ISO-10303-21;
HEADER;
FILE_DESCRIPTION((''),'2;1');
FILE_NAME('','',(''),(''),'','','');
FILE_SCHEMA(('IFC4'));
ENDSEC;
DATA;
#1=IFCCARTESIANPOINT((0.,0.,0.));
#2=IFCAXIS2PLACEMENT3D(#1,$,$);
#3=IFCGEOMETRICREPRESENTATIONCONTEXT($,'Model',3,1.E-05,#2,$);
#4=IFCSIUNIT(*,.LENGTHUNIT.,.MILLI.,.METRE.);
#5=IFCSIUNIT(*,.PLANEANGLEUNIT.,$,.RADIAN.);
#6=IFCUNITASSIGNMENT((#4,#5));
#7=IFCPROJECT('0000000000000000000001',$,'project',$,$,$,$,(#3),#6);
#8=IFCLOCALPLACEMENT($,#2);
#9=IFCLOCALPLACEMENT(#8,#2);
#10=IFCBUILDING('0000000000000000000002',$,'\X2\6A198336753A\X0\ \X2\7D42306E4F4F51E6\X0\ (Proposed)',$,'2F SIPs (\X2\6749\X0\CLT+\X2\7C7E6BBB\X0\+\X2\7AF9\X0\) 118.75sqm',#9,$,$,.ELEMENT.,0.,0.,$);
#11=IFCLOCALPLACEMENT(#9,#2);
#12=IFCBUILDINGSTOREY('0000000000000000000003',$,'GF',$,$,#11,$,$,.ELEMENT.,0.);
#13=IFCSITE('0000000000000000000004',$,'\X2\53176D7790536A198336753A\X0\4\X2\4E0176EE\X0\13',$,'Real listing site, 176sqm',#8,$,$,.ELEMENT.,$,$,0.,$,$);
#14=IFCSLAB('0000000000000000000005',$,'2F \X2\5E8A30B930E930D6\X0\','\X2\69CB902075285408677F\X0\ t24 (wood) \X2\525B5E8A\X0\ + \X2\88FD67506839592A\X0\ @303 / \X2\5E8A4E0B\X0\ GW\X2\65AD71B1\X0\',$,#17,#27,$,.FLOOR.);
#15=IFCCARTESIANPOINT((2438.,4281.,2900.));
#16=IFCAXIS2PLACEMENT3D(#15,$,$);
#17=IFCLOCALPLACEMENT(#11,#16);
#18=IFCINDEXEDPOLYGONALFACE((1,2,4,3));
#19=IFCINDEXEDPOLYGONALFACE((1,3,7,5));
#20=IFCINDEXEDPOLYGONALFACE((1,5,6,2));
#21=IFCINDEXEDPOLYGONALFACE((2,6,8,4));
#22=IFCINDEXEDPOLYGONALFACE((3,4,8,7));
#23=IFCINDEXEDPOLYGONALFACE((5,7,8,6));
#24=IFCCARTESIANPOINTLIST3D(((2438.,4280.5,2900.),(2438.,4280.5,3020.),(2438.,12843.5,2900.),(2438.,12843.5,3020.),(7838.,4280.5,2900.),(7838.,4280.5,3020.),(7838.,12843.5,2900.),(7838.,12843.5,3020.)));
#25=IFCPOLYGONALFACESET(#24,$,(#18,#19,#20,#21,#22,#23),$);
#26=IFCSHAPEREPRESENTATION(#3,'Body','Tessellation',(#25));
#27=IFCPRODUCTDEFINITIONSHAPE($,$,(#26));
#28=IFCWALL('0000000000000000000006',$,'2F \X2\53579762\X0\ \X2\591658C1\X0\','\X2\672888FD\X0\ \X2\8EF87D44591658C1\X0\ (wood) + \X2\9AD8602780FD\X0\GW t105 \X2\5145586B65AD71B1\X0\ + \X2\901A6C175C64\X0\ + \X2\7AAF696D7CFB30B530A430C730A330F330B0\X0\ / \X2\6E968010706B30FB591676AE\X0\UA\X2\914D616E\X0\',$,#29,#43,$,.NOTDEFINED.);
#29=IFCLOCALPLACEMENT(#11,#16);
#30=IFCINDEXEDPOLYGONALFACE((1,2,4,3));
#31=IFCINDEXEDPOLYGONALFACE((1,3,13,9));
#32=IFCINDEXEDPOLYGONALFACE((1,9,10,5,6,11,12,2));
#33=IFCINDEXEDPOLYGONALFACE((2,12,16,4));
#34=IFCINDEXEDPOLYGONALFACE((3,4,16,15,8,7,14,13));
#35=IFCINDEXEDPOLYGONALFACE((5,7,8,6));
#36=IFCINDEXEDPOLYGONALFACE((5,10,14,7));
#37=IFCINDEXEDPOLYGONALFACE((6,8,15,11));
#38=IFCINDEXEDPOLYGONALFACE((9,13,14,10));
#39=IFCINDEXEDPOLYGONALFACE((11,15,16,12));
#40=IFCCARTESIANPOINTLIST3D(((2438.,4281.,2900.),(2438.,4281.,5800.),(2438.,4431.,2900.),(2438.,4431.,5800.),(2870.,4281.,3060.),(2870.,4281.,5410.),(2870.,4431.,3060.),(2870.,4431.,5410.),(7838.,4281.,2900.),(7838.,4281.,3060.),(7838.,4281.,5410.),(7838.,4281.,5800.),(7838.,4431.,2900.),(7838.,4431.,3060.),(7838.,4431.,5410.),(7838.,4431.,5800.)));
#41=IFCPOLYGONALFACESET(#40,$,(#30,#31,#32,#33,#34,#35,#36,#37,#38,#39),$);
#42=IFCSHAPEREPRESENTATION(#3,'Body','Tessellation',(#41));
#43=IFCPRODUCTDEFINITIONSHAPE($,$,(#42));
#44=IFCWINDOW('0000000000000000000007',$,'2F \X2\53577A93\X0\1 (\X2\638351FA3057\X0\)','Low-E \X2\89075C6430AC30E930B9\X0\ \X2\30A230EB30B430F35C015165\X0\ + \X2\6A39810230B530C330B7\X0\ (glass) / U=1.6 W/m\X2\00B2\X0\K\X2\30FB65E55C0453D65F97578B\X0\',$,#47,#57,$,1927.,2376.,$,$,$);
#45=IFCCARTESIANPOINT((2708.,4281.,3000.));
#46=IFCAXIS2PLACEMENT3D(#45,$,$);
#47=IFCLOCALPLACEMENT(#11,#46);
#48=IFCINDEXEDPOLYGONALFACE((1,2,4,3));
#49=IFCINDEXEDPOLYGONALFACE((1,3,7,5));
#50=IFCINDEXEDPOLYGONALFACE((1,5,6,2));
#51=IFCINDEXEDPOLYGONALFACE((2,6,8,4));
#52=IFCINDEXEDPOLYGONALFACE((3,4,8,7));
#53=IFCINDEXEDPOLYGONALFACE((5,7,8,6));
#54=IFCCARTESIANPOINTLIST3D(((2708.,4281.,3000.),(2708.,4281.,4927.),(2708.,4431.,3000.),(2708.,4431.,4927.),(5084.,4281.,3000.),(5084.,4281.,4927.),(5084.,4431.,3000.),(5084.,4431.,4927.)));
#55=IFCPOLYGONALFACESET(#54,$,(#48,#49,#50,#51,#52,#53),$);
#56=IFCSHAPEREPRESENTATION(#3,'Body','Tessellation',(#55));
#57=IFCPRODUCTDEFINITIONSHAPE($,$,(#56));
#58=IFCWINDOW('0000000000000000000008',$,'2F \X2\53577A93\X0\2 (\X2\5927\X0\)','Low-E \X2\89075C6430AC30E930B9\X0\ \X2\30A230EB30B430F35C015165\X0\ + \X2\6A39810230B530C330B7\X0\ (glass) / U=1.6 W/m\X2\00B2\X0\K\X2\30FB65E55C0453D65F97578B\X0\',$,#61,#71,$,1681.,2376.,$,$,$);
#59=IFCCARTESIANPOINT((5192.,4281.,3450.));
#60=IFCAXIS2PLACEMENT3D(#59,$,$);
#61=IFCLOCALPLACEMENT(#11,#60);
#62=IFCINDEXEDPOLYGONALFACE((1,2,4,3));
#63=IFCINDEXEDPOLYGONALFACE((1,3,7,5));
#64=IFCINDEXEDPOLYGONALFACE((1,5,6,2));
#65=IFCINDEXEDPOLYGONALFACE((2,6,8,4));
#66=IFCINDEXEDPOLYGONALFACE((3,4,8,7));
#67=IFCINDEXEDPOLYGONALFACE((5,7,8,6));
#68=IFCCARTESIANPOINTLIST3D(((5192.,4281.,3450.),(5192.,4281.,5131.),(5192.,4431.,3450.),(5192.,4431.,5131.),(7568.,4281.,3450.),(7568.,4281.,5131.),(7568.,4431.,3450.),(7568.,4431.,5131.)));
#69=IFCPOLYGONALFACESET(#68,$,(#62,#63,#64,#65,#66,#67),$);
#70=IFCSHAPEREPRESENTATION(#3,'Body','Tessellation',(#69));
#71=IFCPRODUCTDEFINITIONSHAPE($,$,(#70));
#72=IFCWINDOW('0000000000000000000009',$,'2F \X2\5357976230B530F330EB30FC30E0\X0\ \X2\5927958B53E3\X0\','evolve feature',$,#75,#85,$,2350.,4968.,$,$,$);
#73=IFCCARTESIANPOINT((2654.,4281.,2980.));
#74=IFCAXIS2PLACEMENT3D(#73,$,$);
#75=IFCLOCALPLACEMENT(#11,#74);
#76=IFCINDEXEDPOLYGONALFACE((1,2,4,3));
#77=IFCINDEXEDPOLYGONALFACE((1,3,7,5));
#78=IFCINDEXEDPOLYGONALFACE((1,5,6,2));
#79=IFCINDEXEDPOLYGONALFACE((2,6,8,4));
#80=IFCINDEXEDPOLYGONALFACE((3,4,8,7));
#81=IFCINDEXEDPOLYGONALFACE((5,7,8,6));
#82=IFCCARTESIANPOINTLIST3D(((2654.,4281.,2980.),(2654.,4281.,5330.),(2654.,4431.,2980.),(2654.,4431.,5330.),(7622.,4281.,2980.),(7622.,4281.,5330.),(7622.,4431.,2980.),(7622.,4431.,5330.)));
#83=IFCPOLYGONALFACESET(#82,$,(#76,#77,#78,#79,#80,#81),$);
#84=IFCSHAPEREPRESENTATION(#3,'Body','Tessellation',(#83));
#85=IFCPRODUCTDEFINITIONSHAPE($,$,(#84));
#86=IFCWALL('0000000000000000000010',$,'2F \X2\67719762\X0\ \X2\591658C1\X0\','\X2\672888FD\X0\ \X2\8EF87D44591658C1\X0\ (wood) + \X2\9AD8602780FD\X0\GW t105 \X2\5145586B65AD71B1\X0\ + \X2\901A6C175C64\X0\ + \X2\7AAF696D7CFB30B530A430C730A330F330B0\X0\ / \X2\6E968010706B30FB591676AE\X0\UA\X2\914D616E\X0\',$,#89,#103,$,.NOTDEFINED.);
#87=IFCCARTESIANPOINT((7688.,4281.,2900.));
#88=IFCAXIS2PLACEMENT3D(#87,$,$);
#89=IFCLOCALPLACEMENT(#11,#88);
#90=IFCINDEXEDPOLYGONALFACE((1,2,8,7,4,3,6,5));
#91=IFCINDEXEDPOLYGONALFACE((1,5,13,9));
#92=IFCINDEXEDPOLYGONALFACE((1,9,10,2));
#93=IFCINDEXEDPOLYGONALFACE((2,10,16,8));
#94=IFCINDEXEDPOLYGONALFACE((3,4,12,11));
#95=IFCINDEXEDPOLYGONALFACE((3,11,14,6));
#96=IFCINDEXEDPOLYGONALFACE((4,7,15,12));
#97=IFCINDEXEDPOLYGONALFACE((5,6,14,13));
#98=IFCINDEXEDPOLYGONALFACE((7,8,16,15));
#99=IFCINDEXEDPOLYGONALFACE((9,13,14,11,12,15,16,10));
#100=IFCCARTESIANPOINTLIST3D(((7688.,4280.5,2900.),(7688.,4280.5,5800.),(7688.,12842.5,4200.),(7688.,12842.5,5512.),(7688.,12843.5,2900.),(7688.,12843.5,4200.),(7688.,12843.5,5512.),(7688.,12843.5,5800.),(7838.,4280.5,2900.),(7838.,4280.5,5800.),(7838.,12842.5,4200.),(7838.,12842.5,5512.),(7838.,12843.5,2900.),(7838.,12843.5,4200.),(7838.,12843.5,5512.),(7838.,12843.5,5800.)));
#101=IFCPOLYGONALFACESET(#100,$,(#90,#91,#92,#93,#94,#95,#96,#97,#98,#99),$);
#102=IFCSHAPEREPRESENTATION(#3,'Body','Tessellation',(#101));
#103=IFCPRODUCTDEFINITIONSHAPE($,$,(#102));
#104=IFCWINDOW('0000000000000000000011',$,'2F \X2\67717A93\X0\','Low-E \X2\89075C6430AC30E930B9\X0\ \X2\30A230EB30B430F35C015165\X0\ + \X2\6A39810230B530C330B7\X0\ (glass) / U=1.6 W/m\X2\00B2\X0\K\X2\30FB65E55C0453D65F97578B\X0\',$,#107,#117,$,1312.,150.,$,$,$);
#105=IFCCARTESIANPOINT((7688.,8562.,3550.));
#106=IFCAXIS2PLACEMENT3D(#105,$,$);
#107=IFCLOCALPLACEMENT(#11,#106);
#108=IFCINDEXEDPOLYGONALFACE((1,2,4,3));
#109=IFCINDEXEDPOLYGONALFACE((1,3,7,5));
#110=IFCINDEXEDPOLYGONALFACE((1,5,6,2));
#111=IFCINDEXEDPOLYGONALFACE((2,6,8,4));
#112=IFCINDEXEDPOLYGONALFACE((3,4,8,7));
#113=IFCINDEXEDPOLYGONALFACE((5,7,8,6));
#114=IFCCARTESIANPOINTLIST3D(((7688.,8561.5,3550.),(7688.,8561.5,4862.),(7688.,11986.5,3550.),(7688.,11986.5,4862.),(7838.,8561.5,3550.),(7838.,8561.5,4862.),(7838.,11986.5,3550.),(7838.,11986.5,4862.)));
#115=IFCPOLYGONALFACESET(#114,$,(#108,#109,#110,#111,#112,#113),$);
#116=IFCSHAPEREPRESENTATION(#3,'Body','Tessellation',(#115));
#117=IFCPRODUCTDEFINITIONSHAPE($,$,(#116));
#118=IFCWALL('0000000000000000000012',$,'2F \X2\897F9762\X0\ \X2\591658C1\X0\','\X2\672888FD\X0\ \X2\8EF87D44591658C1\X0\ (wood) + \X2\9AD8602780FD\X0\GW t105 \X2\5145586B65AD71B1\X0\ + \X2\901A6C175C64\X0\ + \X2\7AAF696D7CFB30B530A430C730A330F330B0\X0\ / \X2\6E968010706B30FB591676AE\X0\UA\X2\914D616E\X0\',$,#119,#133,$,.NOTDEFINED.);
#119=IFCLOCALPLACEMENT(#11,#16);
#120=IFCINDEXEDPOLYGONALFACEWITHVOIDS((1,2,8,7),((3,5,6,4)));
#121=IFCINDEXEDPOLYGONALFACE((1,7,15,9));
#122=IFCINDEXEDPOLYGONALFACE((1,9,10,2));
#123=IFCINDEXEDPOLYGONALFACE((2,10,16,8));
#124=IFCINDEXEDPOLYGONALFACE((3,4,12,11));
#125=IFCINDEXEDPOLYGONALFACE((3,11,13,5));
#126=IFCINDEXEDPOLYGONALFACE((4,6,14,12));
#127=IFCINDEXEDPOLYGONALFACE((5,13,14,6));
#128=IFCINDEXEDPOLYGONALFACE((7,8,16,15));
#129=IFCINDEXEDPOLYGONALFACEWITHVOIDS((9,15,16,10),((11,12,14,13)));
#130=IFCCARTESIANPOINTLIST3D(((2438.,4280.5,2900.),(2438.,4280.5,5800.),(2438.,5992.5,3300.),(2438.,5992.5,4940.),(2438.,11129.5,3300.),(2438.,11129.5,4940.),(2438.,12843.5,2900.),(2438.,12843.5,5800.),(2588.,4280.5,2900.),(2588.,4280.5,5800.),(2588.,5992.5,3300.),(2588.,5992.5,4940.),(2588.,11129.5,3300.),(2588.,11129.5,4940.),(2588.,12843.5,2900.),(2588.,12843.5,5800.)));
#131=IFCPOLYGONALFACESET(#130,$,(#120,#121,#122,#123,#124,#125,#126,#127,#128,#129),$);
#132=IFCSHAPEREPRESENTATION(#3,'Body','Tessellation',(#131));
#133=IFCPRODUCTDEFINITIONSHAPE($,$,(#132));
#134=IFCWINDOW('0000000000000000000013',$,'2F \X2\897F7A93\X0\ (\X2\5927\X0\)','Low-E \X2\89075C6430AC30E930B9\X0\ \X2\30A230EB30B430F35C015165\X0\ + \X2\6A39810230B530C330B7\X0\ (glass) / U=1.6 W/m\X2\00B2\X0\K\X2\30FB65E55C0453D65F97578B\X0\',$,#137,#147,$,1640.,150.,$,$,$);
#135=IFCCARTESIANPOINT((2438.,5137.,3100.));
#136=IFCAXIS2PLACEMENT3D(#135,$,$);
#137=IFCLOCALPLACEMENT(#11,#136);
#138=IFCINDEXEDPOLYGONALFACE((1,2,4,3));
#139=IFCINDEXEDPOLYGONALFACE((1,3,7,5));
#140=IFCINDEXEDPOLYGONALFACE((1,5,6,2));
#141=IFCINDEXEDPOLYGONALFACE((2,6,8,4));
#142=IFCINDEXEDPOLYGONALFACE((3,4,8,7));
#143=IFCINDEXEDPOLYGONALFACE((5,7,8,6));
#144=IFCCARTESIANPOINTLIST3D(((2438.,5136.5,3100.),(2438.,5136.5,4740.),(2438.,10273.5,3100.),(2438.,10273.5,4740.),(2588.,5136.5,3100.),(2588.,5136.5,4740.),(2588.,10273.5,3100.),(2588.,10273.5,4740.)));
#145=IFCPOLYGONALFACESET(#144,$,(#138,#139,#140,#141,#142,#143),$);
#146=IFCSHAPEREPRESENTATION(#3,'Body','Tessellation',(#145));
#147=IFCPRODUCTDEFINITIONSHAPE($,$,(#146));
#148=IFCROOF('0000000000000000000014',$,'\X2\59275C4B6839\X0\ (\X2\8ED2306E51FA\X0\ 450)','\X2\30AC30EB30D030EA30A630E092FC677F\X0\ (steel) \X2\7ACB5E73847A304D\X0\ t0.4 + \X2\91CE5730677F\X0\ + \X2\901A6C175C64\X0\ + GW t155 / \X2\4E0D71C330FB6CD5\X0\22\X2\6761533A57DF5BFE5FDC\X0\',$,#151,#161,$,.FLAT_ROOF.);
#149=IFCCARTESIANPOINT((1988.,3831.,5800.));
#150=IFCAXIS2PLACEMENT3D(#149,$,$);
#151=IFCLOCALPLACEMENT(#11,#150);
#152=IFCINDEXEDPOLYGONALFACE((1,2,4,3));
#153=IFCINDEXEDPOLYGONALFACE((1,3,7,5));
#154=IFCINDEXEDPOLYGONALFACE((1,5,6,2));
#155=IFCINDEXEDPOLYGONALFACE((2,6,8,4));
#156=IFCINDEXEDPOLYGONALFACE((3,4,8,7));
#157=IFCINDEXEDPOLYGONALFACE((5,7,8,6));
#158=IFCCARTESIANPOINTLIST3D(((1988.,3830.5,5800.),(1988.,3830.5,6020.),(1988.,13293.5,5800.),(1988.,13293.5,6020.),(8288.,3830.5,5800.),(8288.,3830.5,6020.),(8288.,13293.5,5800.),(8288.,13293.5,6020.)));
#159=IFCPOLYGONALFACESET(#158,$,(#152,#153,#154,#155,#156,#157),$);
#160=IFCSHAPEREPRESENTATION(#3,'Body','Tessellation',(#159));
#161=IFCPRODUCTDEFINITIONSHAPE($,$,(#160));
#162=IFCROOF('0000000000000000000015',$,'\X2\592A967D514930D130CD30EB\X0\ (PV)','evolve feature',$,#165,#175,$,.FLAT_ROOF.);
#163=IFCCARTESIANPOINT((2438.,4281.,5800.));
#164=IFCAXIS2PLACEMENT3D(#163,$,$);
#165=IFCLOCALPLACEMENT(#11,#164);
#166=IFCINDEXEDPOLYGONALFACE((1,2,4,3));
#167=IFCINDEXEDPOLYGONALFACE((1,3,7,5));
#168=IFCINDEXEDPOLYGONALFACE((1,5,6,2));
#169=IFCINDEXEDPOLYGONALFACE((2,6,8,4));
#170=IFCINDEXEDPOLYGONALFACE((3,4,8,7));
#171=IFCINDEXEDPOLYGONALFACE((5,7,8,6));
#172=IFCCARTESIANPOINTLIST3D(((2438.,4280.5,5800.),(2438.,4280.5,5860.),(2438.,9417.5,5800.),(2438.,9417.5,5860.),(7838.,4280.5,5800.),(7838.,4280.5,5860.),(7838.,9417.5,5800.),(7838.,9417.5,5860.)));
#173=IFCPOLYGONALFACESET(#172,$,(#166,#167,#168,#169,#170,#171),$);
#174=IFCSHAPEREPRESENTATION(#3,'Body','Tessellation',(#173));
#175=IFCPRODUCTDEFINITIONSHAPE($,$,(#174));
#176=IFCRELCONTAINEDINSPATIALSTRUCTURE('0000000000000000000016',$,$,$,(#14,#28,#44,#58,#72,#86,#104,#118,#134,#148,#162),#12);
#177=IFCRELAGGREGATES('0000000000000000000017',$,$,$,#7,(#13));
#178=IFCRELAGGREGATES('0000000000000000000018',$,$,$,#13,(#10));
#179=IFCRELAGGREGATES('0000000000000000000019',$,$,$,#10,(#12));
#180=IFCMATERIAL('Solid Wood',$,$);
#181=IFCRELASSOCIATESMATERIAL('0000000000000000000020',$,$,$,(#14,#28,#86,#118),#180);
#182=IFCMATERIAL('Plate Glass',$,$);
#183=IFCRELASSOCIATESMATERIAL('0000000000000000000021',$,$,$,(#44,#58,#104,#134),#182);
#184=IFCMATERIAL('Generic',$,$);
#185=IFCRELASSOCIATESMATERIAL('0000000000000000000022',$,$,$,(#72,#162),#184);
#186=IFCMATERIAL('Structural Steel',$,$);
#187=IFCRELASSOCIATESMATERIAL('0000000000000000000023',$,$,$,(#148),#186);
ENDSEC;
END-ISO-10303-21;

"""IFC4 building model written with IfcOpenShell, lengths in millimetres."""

from ifc_helpers import new_model, si_unit, frame, frame_2d, origin, place, context, project, spatial, rectangle, extrude, material, element, fill, save


model = new_model("IFC4")

# Units and contexts
model_context = context("Model", 3, precision=1e-05, world=origin())
ifc_project = project(units=[si_unit("LENGTHUNIT", "METRE", prefix="MILLI"), si_unit("PLANEANGLEUNIT", "RADIAN")], contexts=[model_context])

# Site, building, storey
site_placement = place(None, origin())
site = spatial("IfcSite", under=ifc_project, at=site_placement, Name="北海道標茶町4丁目13", ObjectType="Real listing site, 176sqm", CompositionType="ELEMENT", RefElevation=0.0)
building_placement = place(site_placement, origin())
building = spatial("IfcBuilding", under=site, at=building_placement, Name="標茶町 終の住処 (Proposed)", ObjectType="2F SIPs (杉CLT+籾殻+竹) 118.75sqm", CompositionType="ELEMENT", ElevationOfRefHeight=0.0, ElevationOfTerrain=0.0)
storey_placement = place(building_placement, origin())
storey = spatial("IfcBuildingStorey", under=building, at=storey_placement, Name="GF", CompositionType="ELEMENT", Elevation=0.0)

# Slab
ifc_material_1 = material(Name="Solid Wood")
slab_placement = place(storey_placement, frame((2438.0, 4281.0, 2900.0)))
element("IfcSlab", 1, at=slab_placement, inside=storey, material=ifc_material_1, Name="2F 床スラブ", Description="構造用合板 t24 (wood) 剛床 + 製材根太 @303 / 床下 GW断熱", PredefinedType="FLOOR", context=model_context, shape_type="SweptSolid", body=[
    extrude(rectangle(XDim=5400.0, YDim=8563.0, at=frame_2d((2700.0, 4281.0))), frame((2438.0, 4281.0, 2900.0)), (0.0, 0.0, 1.0), 120.0),
])

# Wall, openings, windows
wall_1_placement = place(storey_placement, frame((2438.0, 4281.0, 2900.0)))
wall_1 = element("IfcWall", 2, at=wall_1_placement, inside=storey, material=ifc_material_1, Name="2F 南面 外壁", Description="木製 軸組外壁 (wood) + 高性能GW t105 充填断熱 + 通気層 + 窯業系サイディング / 準耐火・外皮UA配慮", PredefinedType="NOTDEFINED", context=model_context, shape_type="SweptSolid", body=[
    extrude(rectangle(XDim=5400.0, YDim=150.0, at=frame_2d((2700.0, 75.0))), frame((2438.0, 4281.0, 2900.0)), (0.0, 0.0, 1.0), 2900.0),
])
opening_1_placement = place(storey_placement, frame((2708.0, 4281.0, 3000.0)))
opening_1 = element("IfcOpeningElement", 3, at=opening_1_placement, cuts=wall_1, PredefinedType="NOTDEFINED", context=model_context, shape_type="SweptSolid", body=[
    extrude(rectangle(XDim=2376.0, YDim=150.0, at=frame_2d((1188.0, 75.0))), frame((2708.0, 4281.0, 3000.0)), (0.0, 0.0, 1.0), 1927.0),
])
opening_2_placement = place(storey_placement, frame((5192.0, 4281.0, 3450.0)))
opening_2 = element("IfcOpeningElement", 4, at=opening_2_placement, cuts=wall_1, PredefinedType="NOTDEFINED", context=model_context, shape_type="SweptSolid", body=[
    extrude(rectangle(XDim=2376.0, YDim=150.0, at=frame_2d((1188.0, 75.0))), frame((5192.0, 4281.0, 3450.0)), (0.0, 0.0, 1.0), 1681.0),
])
opening_3_placement = place(storey_placement, frame((2654.0, 4281.0, 2980.0)))
opening_3 = element("IfcOpeningElement", 5, at=opening_3_placement, cuts=wall_1, PredefinedType="NOTDEFINED", context=model_context, shape_type="SweptSolid", body=[
    extrude(rectangle(XDim=4968.0, YDim=150.0, at=frame_2d((2484.0, 75.0))), frame((2654.0, 4281.0, 2980.0)), (0.0, 0.0, 1.0), 2350.0),
])
ifc_material_2 = material(Name="Plate Glass")
window_1_placement = place(storey_placement, frame((2708.0, 4281.0, 3000.0)))
window_1 = element("IfcWindow", 6, at=window_1_placement, inside=storey, material=ifc_material_2, Name="2F 南窓1 (掃出し)", Description="Low-E 複層ガラス アルゴン封入 + 樹脂サッシ (glass) / U=1.6 W/m²K・日射取得型", OverallHeight=1927.0, OverallWidth=2376.0, context=model_context, shape_type="SweptSolid", body=[
    extrude(rectangle(XDim=2376.0, YDim=150.0, at=frame_2d((1188.0, 75.0))), frame((2708.0, 4281.0, 3000.0)), (0.0, 0.0, 1.0), 1927.0),
])
fill(opening_1, window_1)
window_2_placement = place(storey_placement, frame((5192.0, 4281.0, 3450.0)))
window_2 = element("IfcWindow", 7, at=window_2_placement, inside=storey, material=ifc_material_2, Name="2F 南窓2 (大)", Description="Low-E 複層ガラス アルゴン封入 + 樹脂サッシ (glass) / U=1.6 W/m²K・日射取得型", OverallHeight=1681.0, OverallWidth=2376.0, context=model_context, shape_type="SweptSolid", body=[
    extrude(rectangle(XDim=2376.0, YDim=150.0, at=frame_2d((1188.0, 75.0))), frame((5192.0, 4281.0, 3450.0)), (0.0, 0.0, 1.0), 1681.0),
])
fill(opening_2, window_2)
ifc_material_3 = material(Name="Generic")
window_3_placement = place(storey_placement, frame((2654.0, 4281.0, 2980.0)))
window_3 = element("IfcWindow", 8, at=window_3_placement, inside=storey, material=ifc_material_3, Name="2F 南面サンルーム 大開口", Description="evolve feature", OverallHeight=2350.0, OverallWidth=4968.0, context=model_context, shape_type="SweptSolid", body=[
    extrude(rectangle(XDim=4968.0, YDim=150.0, at=frame_2d((2484.0, 75.0))), frame((2654.0, 4281.0, 2980.0)), (0.0, 0.0, 1.0), 2350.0),
])
fill(opening_3, window_3)

# Walls, openings, windows
wall_2_placement = place(storey_placement, frame((7688.0, 4281.0, 2900.0)))
wall_2 = element("IfcWall", 9, at=wall_2_placement, inside=storey, material=ifc_material_1, Name="2F 東面 外壁", Description="木製 軸組外壁 (wood) + 高性能GW t105 充填断熱 + 通気層 + 窯業系サイディング / 準耐火・外皮UA配慮", PredefinedType="NOTDEFINED", context=model_context, shape_type="SweptSolid", body=[
    extrude(rectangle(XDim=150.0, YDim=8563.0, at=frame_2d((75.0, 4281.0))), frame((7688.0, 4281.0, 2900.0)), (0.0, 0.0, 1.0), 2900.0),
])
opening_4_placement = place(storey_placement, frame((7688.0, 8562.0, 3550.0)))
opening_4 = element("IfcOpeningElement", 10, at=opening_4_placement, cuts=wall_2, PredefinedType="NOTDEFINED", context=model_context, shape_type="SweptSolid", body=[
    extrude(rectangle(XDim=150.0, YDim=3425.0, at=frame_2d((75.0, 1712.0))), frame((7688.0, 8562.0, 3550.0)), (0.0, 0.0, 1.0), 1312.0),
])
window_4_placement = place(storey_placement, frame((7688.0, 8562.0, 3550.0)))
window_4 = element("IfcWindow", 11, at=window_4_placement, inside=storey, material=ifc_material_2, Name="2F 東窓", Description="Low-E 複層ガラス アルゴン封入 + 樹脂サッシ (glass) / U=1.6 W/m²K・日射取得型", OverallHeight=1312.0, OverallWidth=150.0, context=model_context, shape_type="SweptSolid", body=[
    extrude(rectangle(XDim=150.0, YDim=3425.0, at=frame_2d((75.0, 1712.0))), frame((7688.0, 8562.0, 3550.0)), (0.0, 0.0, 1.0), 1312.0),
])
fill(opening_4, window_4)
wall_3_placement = place(storey_placement, frame((2438.0, 4281.0, 2900.0)))
wall_3 = element("IfcWall", 12, at=wall_3_placement, inside=storey, material=ifc_material_1, Name="2F 西面 外壁", Description="木製 軸組外壁 (wood) + 高性能GW t105 充填断熱 + 通気層 + 窯業系サイディング / 準耐火・外皮UA配慮", PredefinedType="NOTDEFINED", context=model_context, shape_type="SweptSolid", body=[
    extrude(rectangle(XDim=150.0, YDim=8563.0, at=frame_2d((75.0, 4281.0))), frame((2438.0, 4281.0, 2900.0)), (0.0, 0.0, 1.0), 2900.0),
])
opening_5_placement = place(storey_placement, frame((2438.0, 5137.0, 3100.0)))
opening_5 = element("IfcOpeningElement", 13, at=opening_5_placement, cuts=wall_3, PredefinedType="NOTDEFINED", context=model_context, shape_type="SweptSolid", body=[
    extrude(rectangle(XDim=150.0, YDim=5137.0, at=frame_2d((75.0, 2568.0))), frame((2438.0, 5137.0, 3100.0)), (0.0, 0.0, 1.0), 1640.0),
])
window_5_placement = place(storey_placement, frame((2438.0, 5137.0, 3100.0)))
window_5 = element("IfcWindow", 14, at=window_5_placement, inside=storey, material=ifc_material_2, Name="2F 西窓 (大)", Description="Low-E 複層ガラス アルゴン封入 + 樹脂サッシ (glass) / U=1.6 W/m²K・日射取得型", OverallHeight=1640.0, OverallWidth=150.0, context=model_context, shape_type="SweptSolid", body=[
    extrude(rectangle(XDim=150.0, YDim=5137.0, at=frame_2d((75.0, 2568.0))), frame((2438.0, 5137.0, 3100.0)), (0.0, 0.0, 1.0), 1640.0),
])
fill(opening_5, window_5)

# Roofs
ifc_material_4 = material(Name="Structural Steel")
roof_1_placement = place(storey_placement, frame((1988.0, 3831.0, 5800.0)))
element("IfcRoof", 15, at=roof_1_placement, inside=storey, material=ifc_material_4, Name="大屋根 (軒の出 450)", Description="ガルバリウム鋼板 (steel) 立平葺き t0.4 + 野地板 + 通気層 + GW t155 / 不燃・法22条区域対応", PredefinedType="FLAT_ROOF", context=model_context, shape_type="SweptSolid", body=[
    extrude(rectangle(XDim=6300.0, YDim=9463.0, at=frame_2d((3150.0, 4731.0))), frame((1988.0, 3831.0, 5800.0)), (0.0, 0.0, 1.0), 220.0),
])
roof_2_placement = place(storey_placement, frame((2438.0, 4281.0, 5800.0)))
element("IfcRoof", 16, at=roof_2_placement, inside=storey, material=ifc_material_3, Name="太陽光パネル (PV)", Description="evolve feature", PredefinedType="FLAT_ROOF", context=model_context, shape_type="SweptSolid", body=[
    extrude(rectangle(XDim=5400.0, YDim=5137.0, at=frame_2d((2700.0, 2568.0))), frame((2438.0, 4281.0, 5800.0)), (0.0, 0.0, 1.0), 60.0),
])

save(model, "model.ifc")
